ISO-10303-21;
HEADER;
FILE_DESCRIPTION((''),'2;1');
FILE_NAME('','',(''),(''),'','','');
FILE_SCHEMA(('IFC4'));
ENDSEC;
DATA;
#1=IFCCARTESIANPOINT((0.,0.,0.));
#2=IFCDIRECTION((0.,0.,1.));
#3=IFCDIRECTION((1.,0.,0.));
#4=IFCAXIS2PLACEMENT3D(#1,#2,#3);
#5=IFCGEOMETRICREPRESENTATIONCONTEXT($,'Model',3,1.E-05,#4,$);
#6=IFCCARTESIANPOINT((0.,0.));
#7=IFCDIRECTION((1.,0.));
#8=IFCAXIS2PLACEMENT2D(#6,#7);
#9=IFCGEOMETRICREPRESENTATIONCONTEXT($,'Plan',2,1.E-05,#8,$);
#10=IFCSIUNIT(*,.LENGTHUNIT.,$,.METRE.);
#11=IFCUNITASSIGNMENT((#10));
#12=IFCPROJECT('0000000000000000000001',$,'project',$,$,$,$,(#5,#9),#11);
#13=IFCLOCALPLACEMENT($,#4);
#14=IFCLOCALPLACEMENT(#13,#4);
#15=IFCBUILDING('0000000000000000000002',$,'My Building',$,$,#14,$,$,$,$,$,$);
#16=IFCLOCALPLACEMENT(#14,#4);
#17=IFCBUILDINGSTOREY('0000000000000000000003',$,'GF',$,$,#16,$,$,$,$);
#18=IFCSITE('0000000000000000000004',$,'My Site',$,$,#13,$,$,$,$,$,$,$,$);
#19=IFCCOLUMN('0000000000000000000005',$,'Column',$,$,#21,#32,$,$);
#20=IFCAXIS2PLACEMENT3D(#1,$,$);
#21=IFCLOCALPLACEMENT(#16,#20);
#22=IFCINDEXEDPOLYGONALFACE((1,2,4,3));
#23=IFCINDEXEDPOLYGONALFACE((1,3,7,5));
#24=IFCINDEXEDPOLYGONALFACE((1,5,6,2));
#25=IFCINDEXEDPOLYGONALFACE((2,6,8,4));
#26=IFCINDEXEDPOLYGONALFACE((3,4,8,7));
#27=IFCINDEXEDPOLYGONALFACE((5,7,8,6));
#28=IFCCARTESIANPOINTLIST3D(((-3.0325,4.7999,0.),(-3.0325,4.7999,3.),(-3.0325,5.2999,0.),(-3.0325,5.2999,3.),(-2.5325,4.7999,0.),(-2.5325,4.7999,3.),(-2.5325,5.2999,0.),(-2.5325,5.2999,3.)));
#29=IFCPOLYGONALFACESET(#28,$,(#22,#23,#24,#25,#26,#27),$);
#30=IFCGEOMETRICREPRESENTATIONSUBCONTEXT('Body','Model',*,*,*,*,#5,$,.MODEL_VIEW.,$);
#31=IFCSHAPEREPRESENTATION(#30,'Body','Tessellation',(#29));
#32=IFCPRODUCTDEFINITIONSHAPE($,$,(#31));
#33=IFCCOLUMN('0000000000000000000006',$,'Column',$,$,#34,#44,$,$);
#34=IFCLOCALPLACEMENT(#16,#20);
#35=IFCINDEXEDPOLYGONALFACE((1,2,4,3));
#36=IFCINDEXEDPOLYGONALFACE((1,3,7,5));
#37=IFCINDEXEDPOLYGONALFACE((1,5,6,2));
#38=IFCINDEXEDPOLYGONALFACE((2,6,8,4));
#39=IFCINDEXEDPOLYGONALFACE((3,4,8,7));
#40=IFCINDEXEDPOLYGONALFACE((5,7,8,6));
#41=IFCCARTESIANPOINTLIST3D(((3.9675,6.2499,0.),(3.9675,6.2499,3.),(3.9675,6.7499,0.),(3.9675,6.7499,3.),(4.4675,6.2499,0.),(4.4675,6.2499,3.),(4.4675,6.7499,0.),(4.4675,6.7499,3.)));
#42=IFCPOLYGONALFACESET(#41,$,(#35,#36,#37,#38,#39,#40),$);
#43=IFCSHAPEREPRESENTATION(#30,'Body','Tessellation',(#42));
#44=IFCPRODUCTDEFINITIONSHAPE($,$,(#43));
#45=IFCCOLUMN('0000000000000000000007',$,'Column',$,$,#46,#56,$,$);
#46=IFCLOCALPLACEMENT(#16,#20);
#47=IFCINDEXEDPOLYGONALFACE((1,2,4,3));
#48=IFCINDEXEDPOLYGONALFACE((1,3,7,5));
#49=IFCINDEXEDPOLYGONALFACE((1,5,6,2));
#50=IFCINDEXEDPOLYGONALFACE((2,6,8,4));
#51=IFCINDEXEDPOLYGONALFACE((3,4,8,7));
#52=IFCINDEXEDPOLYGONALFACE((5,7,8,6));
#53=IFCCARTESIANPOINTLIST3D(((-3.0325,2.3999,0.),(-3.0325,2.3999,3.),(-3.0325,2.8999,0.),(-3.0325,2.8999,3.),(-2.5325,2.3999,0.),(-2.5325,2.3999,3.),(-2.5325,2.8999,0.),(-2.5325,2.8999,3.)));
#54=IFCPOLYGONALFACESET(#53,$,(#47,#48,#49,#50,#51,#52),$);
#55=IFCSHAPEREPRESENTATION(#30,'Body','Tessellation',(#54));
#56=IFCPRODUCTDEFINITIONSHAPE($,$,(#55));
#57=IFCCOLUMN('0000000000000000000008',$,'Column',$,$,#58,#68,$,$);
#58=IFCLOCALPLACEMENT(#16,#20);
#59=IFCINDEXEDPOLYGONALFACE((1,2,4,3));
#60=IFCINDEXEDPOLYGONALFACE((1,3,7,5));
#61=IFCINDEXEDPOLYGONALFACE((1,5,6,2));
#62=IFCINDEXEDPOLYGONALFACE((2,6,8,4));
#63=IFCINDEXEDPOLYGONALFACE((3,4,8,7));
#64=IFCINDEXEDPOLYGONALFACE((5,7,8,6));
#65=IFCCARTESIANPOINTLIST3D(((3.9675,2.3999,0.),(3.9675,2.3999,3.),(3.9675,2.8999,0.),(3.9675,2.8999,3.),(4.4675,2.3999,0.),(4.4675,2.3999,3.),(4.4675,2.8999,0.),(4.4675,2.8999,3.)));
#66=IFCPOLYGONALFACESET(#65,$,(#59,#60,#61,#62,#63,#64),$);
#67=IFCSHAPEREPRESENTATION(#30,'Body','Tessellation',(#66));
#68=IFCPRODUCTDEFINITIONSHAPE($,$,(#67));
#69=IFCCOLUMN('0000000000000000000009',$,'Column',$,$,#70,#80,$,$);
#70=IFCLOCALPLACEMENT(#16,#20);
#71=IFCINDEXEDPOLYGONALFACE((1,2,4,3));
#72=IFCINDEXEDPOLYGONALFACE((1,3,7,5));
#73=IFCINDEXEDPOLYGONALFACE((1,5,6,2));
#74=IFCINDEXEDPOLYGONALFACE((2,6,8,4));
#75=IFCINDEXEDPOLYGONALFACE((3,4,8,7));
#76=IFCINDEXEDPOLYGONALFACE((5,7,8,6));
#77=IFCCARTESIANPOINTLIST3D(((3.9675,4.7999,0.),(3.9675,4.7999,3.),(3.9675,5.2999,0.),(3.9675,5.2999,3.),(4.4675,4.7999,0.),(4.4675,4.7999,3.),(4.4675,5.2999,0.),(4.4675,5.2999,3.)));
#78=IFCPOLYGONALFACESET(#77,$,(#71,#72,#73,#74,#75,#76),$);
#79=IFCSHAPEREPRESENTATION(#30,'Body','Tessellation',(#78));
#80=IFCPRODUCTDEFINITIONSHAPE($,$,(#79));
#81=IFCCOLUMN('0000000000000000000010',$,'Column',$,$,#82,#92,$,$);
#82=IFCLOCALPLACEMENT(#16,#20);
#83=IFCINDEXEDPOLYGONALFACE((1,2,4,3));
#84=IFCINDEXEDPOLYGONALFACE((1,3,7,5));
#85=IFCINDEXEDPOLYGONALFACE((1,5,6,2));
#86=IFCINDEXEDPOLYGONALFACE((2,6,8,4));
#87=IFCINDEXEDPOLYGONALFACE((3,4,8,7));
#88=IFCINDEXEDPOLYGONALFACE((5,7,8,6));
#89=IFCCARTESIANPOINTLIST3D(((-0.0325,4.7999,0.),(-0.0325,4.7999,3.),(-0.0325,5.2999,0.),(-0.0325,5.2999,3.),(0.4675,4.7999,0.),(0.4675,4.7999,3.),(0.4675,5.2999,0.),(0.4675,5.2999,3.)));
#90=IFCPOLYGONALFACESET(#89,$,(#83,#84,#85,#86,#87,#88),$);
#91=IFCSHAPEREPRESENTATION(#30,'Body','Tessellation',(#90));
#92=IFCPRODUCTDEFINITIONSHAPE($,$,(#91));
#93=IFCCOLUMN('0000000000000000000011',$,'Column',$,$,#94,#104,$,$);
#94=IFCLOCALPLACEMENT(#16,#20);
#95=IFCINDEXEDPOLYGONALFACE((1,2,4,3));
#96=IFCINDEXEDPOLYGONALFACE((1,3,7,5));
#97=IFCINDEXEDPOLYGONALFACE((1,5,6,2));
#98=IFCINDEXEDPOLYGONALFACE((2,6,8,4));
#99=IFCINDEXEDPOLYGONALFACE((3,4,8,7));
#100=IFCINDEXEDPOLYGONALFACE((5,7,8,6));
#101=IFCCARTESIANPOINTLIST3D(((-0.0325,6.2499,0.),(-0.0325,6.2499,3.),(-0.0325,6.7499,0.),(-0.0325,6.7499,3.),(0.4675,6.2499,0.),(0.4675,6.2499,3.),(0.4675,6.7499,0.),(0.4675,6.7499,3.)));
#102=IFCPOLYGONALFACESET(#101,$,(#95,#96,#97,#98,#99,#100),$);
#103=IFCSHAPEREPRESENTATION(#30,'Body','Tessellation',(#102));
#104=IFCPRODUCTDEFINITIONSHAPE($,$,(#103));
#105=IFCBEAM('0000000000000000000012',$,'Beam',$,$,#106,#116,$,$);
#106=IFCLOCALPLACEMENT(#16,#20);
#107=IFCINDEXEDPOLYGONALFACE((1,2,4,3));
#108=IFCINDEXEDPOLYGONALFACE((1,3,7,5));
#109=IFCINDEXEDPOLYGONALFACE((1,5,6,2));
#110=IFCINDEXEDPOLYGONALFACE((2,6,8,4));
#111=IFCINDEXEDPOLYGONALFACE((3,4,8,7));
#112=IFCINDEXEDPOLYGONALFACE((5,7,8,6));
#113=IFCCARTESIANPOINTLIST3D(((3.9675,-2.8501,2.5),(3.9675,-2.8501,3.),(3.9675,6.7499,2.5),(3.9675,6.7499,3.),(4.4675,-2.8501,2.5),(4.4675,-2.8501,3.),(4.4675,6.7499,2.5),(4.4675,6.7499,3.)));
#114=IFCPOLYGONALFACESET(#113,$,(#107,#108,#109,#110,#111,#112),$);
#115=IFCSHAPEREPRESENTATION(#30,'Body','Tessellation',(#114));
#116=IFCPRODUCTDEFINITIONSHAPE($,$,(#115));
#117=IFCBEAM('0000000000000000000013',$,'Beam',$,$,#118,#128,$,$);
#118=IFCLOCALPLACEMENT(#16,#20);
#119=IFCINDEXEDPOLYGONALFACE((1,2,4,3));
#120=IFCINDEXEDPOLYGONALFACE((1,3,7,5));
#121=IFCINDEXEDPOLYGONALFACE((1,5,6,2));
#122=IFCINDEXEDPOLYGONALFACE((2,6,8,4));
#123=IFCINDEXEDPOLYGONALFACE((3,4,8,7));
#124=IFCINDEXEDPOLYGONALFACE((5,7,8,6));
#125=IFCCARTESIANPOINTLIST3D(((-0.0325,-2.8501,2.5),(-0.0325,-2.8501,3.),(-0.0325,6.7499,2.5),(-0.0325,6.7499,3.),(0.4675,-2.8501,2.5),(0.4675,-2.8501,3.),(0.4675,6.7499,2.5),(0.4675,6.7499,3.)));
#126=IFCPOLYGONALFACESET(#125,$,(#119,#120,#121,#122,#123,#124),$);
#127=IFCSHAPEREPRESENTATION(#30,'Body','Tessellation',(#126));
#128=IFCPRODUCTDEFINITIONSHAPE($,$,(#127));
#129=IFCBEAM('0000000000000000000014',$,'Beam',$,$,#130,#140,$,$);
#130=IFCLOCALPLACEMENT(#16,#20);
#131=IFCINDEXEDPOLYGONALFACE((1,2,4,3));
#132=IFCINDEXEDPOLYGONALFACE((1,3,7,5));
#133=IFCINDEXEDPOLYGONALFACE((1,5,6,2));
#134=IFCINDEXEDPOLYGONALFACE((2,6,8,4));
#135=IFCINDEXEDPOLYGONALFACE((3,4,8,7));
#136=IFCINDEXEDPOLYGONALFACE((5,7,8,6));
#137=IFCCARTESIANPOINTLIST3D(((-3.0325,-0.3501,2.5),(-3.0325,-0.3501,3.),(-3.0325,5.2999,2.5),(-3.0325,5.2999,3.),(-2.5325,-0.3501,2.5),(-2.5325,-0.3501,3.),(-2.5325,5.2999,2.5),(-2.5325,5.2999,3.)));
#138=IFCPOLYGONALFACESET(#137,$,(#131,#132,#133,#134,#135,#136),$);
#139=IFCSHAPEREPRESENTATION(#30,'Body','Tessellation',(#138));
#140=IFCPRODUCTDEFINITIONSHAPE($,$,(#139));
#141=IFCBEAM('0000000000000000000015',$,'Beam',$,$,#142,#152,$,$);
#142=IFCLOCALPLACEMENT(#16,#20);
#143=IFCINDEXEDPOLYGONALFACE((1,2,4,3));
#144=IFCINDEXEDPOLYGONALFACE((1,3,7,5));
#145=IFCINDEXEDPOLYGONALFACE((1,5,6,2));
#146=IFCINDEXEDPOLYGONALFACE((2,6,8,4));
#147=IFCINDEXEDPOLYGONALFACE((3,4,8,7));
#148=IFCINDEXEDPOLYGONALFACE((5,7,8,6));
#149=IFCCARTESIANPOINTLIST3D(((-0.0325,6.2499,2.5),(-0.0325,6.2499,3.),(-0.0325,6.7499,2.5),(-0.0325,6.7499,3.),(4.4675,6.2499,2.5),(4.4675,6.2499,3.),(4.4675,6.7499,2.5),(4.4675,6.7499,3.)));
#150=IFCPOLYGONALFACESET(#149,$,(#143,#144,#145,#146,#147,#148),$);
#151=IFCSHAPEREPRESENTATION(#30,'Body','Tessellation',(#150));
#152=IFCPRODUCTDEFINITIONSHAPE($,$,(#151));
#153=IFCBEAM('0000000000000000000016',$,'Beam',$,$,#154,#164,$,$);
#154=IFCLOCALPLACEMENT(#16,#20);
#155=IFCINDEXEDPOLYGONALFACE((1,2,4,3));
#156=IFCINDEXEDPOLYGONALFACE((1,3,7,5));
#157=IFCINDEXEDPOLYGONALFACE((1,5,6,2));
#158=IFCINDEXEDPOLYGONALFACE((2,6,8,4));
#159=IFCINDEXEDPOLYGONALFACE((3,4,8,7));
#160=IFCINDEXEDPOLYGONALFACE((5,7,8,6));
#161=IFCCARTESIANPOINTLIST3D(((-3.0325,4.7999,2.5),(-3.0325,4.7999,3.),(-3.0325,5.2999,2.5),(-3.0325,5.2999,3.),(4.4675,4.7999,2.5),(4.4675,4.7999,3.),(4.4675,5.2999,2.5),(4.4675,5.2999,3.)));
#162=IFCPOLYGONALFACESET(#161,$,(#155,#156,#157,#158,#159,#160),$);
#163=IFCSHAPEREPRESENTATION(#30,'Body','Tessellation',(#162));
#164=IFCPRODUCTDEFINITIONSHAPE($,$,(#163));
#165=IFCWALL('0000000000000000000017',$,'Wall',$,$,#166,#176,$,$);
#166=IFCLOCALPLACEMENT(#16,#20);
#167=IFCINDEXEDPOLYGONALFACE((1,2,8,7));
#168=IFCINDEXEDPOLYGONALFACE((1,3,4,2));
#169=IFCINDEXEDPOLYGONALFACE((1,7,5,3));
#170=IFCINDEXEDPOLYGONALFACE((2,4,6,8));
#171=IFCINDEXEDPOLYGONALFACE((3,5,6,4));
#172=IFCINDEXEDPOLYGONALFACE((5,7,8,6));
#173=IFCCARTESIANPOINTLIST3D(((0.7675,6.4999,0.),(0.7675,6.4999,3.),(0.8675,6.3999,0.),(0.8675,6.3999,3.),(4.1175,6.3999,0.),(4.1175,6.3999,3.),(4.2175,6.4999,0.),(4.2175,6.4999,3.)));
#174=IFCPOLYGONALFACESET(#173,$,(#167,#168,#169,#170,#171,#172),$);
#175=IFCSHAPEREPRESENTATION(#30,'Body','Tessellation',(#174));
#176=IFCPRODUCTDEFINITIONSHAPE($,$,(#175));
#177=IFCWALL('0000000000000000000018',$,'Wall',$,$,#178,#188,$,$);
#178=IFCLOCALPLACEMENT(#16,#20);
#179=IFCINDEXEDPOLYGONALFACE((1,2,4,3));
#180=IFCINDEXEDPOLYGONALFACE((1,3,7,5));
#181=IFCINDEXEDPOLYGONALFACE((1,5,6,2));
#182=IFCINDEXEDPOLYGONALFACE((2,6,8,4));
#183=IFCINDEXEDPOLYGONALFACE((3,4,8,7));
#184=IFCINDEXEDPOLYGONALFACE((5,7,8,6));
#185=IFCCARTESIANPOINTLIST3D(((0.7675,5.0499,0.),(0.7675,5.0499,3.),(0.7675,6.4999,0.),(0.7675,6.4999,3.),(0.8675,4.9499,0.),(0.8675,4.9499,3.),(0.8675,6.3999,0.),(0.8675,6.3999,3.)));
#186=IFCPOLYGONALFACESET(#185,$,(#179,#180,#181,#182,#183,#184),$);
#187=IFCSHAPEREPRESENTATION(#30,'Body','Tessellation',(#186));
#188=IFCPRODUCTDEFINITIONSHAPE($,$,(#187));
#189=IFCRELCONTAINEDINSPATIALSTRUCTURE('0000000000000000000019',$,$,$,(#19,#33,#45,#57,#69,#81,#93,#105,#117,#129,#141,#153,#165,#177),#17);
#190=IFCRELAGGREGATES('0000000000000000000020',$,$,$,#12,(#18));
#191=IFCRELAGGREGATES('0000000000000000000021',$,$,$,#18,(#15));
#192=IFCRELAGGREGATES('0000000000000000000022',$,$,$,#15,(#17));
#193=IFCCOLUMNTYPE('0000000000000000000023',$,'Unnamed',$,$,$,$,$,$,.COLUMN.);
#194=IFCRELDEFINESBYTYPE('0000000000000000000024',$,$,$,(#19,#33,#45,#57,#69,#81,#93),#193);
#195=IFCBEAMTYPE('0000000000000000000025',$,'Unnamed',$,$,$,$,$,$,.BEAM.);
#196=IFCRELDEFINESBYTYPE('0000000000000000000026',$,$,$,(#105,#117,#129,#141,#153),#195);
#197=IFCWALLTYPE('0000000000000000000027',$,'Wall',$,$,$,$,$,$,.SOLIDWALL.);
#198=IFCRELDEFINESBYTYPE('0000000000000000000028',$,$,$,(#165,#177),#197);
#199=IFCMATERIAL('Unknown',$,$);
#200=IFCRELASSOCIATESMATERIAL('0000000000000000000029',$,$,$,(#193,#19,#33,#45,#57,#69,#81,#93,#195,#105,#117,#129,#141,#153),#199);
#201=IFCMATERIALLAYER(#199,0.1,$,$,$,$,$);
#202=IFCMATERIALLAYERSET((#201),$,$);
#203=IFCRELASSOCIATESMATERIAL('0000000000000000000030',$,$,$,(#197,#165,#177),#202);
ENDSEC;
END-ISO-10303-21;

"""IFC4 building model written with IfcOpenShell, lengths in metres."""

from ifc_helpers import new_model, si_unit, frame, origin_with_axes, origin_2d_with_axis, place, context, subcontext, project, spatial, line, indexed_curve, rectangle, outline, extrude, material, layer, layer_set, layer_usage, material_profile, profile_set, profile_usage, type_object, element, save


model = new_model("IFC4")

# Units and contexts
model_context = context("Model", 3, precision=1e-05, world=origin_with_axes())
plan_context = context("Plan", 2, precision=1e-05, world=origin_2d_with_axis())
body_context_1 = subcontext(model_context, "Body", "Model", "MODEL_VIEW")
ifc_project = project(units=[si_unit("LENGTHUNIT", "METRE")], contexts=[model_context, plan_context])

# Site, building, storey
site_placement = place(None, origin_with_axes())
site = spatial("IfcSite", under=ifc_project, at=site_placement, Name="My Site")
building_placement = place(site_placement, origin_with_axes())
building = spatial("IfcBuilding", under=site, at=building_placement, Name="My Building")
storey_placement = place(building_placement, origin_with_axes())
storey = spatial("IfcBuildingStorey", under=building, at=storey_placement, Name="GF")

# Columns
ifc_material_1 = material(Name="Unknown")
ifc_material_profile_1 = material_profile(ifc_material_1, rectangle(XDim=0.5, YDim=0.5))
ifc_profile_set_1 = profile_set([ifc_material_profile_1])
ifc_profile_usage_1 = profile_usage(ifc_profile_set_1, cardinal=5)
column_type = type_object("IfcColumnType", Name="Unnamed", PredefinedType="COLUMN", material=ifc_profile_set_1)
column_1_placement = place(storey_placement, frame((-2.7825, 5.0499, 0.0), z_axis=(0.0, 0.0, 1.0), x_axis=(1.0, 0.0, 0.0)))
element("IfcColumn", 1, at=column_1_placement, inside=storey, type_object=column_type, material=ifc_profile_usage_1, Name="Column", context=body_context_1, shape_type="SweptSolid", body=[
    extrude(rectangle(XDim=0.5, YDim=0.5), origin_with_axes(), (0.0, 0.0, 1.0), 3.0),
])
ifc_profile_usage_2 = profile_usage(ifc_profile_set_1, cardinal=5)
column_2_placement = place(storey_placement, frame((4.2175, 6.4999, 0.0), z_axis=(0.0, 0.0, 1.0), x_axis=(1.0, 0.0, 0.0)))
element("IfcColumn", 2, at=column_2_placement, inside=storey, type_object=column_type, material=ifc_profile_usage_2, Name="Column", context=body_context_1, shape_type="SweptSolid", body=[
    extrude(rectangle(XDim=0.5, YDim=0.5), origin_with_axes(), (0.0, 0.0, 1.0), 3.0),
])
ifc_profile_usage_3 = profile_usage(ifc_profile_set_1, cardinal=5)
column_3_placement = place(storey_placement, frame((-2.7825, 2.6499, 0.0), z_axis=(0.0, 0.0, 1.0), x_axis=(1.0, 0.0, 0.0)))
element("IfcColumn", 3, at=column_3_placement, inside=storey, type_object=column_type, material=ifc_profile_usage_3, Name="Column", context=body_context_1, shape_type="SweptSolid", body=[
    extrude(rectangle(XDim=0.5, YDim=0.5), origin_with_axes(), (0.0, 0.0, 1.0), 3.0),
])
ifc_profile_usage_4 = profile_usage(ifc_profile_set_1, cardinal=5)
column_4_placement = place(storey_placement, frame((4.2175, 2.6499, 0.0), z_axis=(0.0, 0.0, 1.0), x_axis=(1.0, 0.0, 0.0)))
element("IfcColumn", 4, at=column_4_placement, inside=storey, type_object=column_type, material=ifc_profile_usage_4, Name="Column", context=body_context_1, shape_type="SweptSolid", body=[
    extrude(rectangle(XDim=0.5, YDim=0.5), origin_with_axes(), (0.0, 0.0, 1.0), 3.0),
])
ifc_profile_usage_5 = profile_usage(ifc_profile_set_1, cardinal=5)
column_5_placement = place(storey_placement, frame((4.2175, 5.0499, 0.0), z_axis=(0.0, 0.0, 1.0), x_axis=(1.0, 0.0, 0.0)))
element("IfcColumn", 5, at=column_5_placement, inside=storey, type_object=column_type, material=ifc_profile_usage_5, Name="Column", context=body_context_1, shape_type="SweptSolid", body=[
    extrude(rectangle(XDim=0.5, YDim=0.5), origin_with_axes(), (0.0, 0.0, 1.0), 3.0),
])
ifc_profile_usage_6 = profile_usage(ifc_profile_set_1, cardinal=5)
column_6_placement = place(storey_placement, frame((0.2175, 5.0499, 0.0), z_axis=(0.0, 0.0, 1.0), x_axis=(1.0, 0.0, 0.0)))
element("IfcColumn", 6, at=column_6_placement, inside=storey, type_object=column_type, material=ifc_profile_usage_6, Name="Column", context=body_context_1, shape_type="SweptSolid", body=[
    extrude(rectangle(XDim=0.5, YDim=0.5), origin_with_axes(), (0.0, 0.0, 1.0), 3.0),
])
ifc_profile_usage_7 = profile_usage(ifc_profile_set_1, cardinal=5)
column_7_placement = place(storey_placement, frame((0.2175, 6.4999, 0.0), z_axis=(0.0, 0.0, 1.0), x_axis=(1.0, 0.0, 0.0)))
element("IfcColumn", 7, at=column_7_placement, inside=storey, type_object=column_type, material=ifc_profile_usage_7, Name="Column", context=body_context_1, shape_type="SweptSolid", body=[
    extrude(rectangle(XDim=0.5, YDim=0.5), origin_with_axes(), (0.0, 0.0, 1.0), 3.0),
])

# Beams
ifc_material_profile_2 = material_profile(ifc_material_1, rectangle(XDim=0.5, YDim=0.5))
ifc_profile_set_2 = profile_set([ifc_material_profile_2])
ifc_profile_usage_8 = profile_usage(ifc_profile_set_2, cardinal=7)
beam_type = type_object("IfcBeamType", Name="Unnamed", PredefinedType="BEAM", material=ifc_profile_set_2)
beam_1_placement = place(storey_placement, frame((4.4675, 6.7499, 3.0), z_axis=(0.0, -1.0, 0.0), x_axis=(1.0, 0.0, 0.0)))
element("IfcBeam", 8, at=beam_1_placement, inside=storey, type_object=beam_type, material=ifc_profile_usage_8, Name="Beam", context=body_context_1, shape_type="SweptSolid", body=[
    extrude(rectangle(XDim=0.5, YDim=0.5), frame((-0.25, -0.25, 0.0), z_axis=(0.0, 0.0, 1.0), x_axis=(1.0, 0.0, 0.0)), (0.0, 0.0, 1.0), 9.6),
])
ifc_profile_usage_9 = profile_usage(ifc_profile_set_2, cardinal=7)
beam_2_placement = place(storey_placement, frame((0.4675, 6.7499, 3.0), z_axis=(0.0, -1.0, 0.0), x_axis=(1.0, 0.0, 0.0)))
element("IfcBeam", 9, at=beam_2_placement, inside=storey, type_object=beam_type, material=ifc_profile_usage_9, Name="Beam", context=body_context_1, shape_type="SweptSolid", body=[
    extrude(rectangle(XDim=0.5, YDim=0.5), frame((-0.25, -0.25, 0.0), z_axis=(0.0, 0.0, 1.0), x_axis=(1.0, 0.0, 0.0)), (0.0, 0.0, 1.0), 9.6),
])
ifc_profile_usage_10 = profile_usage(ifc_profile_set_2, cardinal=7)
beam_3_placement = place(storey_placement, frame((-2.5325, 5.2999, 3.0), z_axis=(0.0, -1.0, 0.0), x_axis=(1.0, 0.0, 0.0)))
element("IfcBeam", 10, at=beam_3_placement, inside=storey, type_object=beam_type, material=ifc_profile_usage_10, Name="Beam", context=body_context_1, shape_type="SweptSolid", body=[
    extrude(rectangle(XDim=0.5, YDim=0.5), frame((-0.25, -0.25, 0.0), z_axis=(0.0, 0.0, 1.0), x_axis=(1.0, 0.0, 0.0)), (0.0, 0.0, 1.0), 5.65),
])
ifc_profile_usage_11 = profile_usage(ifc_profile_set_2, cardinal=7)
beam_4_placement = place(storey_placement, frame((4.4675, 6.2499, 3.0), z_axis=(-1.0, 0.0, 0.0), x_axis=(0.0, -1.0, 0.0)))
element("IfcBeam", 11, at=beam_4_placement, inside=storey, type_object=beam_type, material=ifc_profile_usage_11, Name="Beam", context=body_context_1, shape_type="SweptSolid", body=[
    extrude(rectangle(XDim=0.5, YDim=0.5), frame((-0.25, -0.25, 0.0), z_axis=(0.0, 0.0, 1.0), x_axis=(1.0, 0.0, 0.0)), (0.0, 0.0, 1.0), 4.5),
])
ifc_profile_usage_12 = profile_usage(ifc_profile_set_2, cardinal=7)
beam_5_placement = place(storey_placement, frame((4.4675, 4.7999, 3.0), z_axis=(-1.0, 0.0, 0.0), x_axis=(0.0, -1.0, 0.0)))
element("IfcBeam", 12, at=beam_5_placement, inside=storey, type_object=beam_type, material=ifc_profile_usage_12, Name="Beam", context=body_context_1, shape_type="SweptSolid", body=[
    extrude(rectangle(XDim=0.5, YDim=0.5), frame((-0.25, -0.25, 0.0), z_axis=(0.0, 0.0, 1.0), x_axis=(1.0, 0.0, 0.0)), (0.0, 0.0, 1.0), 7.5),
])

# Walls
ifc_layer_1 = layer(ifc_material_1, 0.1)
ifc_layer_set_1 = layer_set([ifc_layer_1])
ifc_layer_usage_1 = layer_usage(ifc_layer_set_1, "AXIS2", "POSITIVE", 0.0)
wall_type = type_object("IfcWallType", Name="Wall", PredefinedType="SOLIDWALL", material=ifc_layer_set_1)
wall_1_placement = place(storey_placement, frame((4.2175, 6.4999, 0.0), z_axis=(0.0, 0.0, 1.0), x_axis=(-1.0, 0.0, 0.0)))
element("IfcWall", 13, at=wall_1_placement, inside=storey, type_object=wall_type, material=ifc_layer_usage_1, Name="Wall", context=body_context_1, shape_type="SweptSolid", body=[
    extrude(outline(indexed_curve([(0.0, 0.0), (0.1, 0.1), (3.35, 0.1), (3.45, 0.0)], segments=[line(1, 2, 3, 4, 1)])), origin_with_axes(), (0.0, 0.0, 1.0), 3.0),
])
ifc_layer_usage_2 = layer_usage(ifc_layer_set_1, "AXIS2", "POSITIVE", 0.0)
wall_2_placement = place(storey_placement, frame((0.7675, 6.4999, 0.0), z_axis=(0.0, 0.0, 1.0), x_axis=(0.0, -1.0, 0.0)))
element("IfcWall", 14, at=wall_2_placement, inside=storey, type_object=wall_type, material=ifc_layer_usage_2, Name="Wall", context=body_context_1, shape_type="SweptSolid", body=[
    extrude(outline(indexed_curve([(0.0, 0.0), (0.1, 0.1), (1.55, 0.1), (1.45, 0.0)], segments=[line(1, 2, 3, 4, 1)])), origin_with_axes(), (0.0, 0.0, 1.0), 3.0),
])

save(model, "model.ifc")
